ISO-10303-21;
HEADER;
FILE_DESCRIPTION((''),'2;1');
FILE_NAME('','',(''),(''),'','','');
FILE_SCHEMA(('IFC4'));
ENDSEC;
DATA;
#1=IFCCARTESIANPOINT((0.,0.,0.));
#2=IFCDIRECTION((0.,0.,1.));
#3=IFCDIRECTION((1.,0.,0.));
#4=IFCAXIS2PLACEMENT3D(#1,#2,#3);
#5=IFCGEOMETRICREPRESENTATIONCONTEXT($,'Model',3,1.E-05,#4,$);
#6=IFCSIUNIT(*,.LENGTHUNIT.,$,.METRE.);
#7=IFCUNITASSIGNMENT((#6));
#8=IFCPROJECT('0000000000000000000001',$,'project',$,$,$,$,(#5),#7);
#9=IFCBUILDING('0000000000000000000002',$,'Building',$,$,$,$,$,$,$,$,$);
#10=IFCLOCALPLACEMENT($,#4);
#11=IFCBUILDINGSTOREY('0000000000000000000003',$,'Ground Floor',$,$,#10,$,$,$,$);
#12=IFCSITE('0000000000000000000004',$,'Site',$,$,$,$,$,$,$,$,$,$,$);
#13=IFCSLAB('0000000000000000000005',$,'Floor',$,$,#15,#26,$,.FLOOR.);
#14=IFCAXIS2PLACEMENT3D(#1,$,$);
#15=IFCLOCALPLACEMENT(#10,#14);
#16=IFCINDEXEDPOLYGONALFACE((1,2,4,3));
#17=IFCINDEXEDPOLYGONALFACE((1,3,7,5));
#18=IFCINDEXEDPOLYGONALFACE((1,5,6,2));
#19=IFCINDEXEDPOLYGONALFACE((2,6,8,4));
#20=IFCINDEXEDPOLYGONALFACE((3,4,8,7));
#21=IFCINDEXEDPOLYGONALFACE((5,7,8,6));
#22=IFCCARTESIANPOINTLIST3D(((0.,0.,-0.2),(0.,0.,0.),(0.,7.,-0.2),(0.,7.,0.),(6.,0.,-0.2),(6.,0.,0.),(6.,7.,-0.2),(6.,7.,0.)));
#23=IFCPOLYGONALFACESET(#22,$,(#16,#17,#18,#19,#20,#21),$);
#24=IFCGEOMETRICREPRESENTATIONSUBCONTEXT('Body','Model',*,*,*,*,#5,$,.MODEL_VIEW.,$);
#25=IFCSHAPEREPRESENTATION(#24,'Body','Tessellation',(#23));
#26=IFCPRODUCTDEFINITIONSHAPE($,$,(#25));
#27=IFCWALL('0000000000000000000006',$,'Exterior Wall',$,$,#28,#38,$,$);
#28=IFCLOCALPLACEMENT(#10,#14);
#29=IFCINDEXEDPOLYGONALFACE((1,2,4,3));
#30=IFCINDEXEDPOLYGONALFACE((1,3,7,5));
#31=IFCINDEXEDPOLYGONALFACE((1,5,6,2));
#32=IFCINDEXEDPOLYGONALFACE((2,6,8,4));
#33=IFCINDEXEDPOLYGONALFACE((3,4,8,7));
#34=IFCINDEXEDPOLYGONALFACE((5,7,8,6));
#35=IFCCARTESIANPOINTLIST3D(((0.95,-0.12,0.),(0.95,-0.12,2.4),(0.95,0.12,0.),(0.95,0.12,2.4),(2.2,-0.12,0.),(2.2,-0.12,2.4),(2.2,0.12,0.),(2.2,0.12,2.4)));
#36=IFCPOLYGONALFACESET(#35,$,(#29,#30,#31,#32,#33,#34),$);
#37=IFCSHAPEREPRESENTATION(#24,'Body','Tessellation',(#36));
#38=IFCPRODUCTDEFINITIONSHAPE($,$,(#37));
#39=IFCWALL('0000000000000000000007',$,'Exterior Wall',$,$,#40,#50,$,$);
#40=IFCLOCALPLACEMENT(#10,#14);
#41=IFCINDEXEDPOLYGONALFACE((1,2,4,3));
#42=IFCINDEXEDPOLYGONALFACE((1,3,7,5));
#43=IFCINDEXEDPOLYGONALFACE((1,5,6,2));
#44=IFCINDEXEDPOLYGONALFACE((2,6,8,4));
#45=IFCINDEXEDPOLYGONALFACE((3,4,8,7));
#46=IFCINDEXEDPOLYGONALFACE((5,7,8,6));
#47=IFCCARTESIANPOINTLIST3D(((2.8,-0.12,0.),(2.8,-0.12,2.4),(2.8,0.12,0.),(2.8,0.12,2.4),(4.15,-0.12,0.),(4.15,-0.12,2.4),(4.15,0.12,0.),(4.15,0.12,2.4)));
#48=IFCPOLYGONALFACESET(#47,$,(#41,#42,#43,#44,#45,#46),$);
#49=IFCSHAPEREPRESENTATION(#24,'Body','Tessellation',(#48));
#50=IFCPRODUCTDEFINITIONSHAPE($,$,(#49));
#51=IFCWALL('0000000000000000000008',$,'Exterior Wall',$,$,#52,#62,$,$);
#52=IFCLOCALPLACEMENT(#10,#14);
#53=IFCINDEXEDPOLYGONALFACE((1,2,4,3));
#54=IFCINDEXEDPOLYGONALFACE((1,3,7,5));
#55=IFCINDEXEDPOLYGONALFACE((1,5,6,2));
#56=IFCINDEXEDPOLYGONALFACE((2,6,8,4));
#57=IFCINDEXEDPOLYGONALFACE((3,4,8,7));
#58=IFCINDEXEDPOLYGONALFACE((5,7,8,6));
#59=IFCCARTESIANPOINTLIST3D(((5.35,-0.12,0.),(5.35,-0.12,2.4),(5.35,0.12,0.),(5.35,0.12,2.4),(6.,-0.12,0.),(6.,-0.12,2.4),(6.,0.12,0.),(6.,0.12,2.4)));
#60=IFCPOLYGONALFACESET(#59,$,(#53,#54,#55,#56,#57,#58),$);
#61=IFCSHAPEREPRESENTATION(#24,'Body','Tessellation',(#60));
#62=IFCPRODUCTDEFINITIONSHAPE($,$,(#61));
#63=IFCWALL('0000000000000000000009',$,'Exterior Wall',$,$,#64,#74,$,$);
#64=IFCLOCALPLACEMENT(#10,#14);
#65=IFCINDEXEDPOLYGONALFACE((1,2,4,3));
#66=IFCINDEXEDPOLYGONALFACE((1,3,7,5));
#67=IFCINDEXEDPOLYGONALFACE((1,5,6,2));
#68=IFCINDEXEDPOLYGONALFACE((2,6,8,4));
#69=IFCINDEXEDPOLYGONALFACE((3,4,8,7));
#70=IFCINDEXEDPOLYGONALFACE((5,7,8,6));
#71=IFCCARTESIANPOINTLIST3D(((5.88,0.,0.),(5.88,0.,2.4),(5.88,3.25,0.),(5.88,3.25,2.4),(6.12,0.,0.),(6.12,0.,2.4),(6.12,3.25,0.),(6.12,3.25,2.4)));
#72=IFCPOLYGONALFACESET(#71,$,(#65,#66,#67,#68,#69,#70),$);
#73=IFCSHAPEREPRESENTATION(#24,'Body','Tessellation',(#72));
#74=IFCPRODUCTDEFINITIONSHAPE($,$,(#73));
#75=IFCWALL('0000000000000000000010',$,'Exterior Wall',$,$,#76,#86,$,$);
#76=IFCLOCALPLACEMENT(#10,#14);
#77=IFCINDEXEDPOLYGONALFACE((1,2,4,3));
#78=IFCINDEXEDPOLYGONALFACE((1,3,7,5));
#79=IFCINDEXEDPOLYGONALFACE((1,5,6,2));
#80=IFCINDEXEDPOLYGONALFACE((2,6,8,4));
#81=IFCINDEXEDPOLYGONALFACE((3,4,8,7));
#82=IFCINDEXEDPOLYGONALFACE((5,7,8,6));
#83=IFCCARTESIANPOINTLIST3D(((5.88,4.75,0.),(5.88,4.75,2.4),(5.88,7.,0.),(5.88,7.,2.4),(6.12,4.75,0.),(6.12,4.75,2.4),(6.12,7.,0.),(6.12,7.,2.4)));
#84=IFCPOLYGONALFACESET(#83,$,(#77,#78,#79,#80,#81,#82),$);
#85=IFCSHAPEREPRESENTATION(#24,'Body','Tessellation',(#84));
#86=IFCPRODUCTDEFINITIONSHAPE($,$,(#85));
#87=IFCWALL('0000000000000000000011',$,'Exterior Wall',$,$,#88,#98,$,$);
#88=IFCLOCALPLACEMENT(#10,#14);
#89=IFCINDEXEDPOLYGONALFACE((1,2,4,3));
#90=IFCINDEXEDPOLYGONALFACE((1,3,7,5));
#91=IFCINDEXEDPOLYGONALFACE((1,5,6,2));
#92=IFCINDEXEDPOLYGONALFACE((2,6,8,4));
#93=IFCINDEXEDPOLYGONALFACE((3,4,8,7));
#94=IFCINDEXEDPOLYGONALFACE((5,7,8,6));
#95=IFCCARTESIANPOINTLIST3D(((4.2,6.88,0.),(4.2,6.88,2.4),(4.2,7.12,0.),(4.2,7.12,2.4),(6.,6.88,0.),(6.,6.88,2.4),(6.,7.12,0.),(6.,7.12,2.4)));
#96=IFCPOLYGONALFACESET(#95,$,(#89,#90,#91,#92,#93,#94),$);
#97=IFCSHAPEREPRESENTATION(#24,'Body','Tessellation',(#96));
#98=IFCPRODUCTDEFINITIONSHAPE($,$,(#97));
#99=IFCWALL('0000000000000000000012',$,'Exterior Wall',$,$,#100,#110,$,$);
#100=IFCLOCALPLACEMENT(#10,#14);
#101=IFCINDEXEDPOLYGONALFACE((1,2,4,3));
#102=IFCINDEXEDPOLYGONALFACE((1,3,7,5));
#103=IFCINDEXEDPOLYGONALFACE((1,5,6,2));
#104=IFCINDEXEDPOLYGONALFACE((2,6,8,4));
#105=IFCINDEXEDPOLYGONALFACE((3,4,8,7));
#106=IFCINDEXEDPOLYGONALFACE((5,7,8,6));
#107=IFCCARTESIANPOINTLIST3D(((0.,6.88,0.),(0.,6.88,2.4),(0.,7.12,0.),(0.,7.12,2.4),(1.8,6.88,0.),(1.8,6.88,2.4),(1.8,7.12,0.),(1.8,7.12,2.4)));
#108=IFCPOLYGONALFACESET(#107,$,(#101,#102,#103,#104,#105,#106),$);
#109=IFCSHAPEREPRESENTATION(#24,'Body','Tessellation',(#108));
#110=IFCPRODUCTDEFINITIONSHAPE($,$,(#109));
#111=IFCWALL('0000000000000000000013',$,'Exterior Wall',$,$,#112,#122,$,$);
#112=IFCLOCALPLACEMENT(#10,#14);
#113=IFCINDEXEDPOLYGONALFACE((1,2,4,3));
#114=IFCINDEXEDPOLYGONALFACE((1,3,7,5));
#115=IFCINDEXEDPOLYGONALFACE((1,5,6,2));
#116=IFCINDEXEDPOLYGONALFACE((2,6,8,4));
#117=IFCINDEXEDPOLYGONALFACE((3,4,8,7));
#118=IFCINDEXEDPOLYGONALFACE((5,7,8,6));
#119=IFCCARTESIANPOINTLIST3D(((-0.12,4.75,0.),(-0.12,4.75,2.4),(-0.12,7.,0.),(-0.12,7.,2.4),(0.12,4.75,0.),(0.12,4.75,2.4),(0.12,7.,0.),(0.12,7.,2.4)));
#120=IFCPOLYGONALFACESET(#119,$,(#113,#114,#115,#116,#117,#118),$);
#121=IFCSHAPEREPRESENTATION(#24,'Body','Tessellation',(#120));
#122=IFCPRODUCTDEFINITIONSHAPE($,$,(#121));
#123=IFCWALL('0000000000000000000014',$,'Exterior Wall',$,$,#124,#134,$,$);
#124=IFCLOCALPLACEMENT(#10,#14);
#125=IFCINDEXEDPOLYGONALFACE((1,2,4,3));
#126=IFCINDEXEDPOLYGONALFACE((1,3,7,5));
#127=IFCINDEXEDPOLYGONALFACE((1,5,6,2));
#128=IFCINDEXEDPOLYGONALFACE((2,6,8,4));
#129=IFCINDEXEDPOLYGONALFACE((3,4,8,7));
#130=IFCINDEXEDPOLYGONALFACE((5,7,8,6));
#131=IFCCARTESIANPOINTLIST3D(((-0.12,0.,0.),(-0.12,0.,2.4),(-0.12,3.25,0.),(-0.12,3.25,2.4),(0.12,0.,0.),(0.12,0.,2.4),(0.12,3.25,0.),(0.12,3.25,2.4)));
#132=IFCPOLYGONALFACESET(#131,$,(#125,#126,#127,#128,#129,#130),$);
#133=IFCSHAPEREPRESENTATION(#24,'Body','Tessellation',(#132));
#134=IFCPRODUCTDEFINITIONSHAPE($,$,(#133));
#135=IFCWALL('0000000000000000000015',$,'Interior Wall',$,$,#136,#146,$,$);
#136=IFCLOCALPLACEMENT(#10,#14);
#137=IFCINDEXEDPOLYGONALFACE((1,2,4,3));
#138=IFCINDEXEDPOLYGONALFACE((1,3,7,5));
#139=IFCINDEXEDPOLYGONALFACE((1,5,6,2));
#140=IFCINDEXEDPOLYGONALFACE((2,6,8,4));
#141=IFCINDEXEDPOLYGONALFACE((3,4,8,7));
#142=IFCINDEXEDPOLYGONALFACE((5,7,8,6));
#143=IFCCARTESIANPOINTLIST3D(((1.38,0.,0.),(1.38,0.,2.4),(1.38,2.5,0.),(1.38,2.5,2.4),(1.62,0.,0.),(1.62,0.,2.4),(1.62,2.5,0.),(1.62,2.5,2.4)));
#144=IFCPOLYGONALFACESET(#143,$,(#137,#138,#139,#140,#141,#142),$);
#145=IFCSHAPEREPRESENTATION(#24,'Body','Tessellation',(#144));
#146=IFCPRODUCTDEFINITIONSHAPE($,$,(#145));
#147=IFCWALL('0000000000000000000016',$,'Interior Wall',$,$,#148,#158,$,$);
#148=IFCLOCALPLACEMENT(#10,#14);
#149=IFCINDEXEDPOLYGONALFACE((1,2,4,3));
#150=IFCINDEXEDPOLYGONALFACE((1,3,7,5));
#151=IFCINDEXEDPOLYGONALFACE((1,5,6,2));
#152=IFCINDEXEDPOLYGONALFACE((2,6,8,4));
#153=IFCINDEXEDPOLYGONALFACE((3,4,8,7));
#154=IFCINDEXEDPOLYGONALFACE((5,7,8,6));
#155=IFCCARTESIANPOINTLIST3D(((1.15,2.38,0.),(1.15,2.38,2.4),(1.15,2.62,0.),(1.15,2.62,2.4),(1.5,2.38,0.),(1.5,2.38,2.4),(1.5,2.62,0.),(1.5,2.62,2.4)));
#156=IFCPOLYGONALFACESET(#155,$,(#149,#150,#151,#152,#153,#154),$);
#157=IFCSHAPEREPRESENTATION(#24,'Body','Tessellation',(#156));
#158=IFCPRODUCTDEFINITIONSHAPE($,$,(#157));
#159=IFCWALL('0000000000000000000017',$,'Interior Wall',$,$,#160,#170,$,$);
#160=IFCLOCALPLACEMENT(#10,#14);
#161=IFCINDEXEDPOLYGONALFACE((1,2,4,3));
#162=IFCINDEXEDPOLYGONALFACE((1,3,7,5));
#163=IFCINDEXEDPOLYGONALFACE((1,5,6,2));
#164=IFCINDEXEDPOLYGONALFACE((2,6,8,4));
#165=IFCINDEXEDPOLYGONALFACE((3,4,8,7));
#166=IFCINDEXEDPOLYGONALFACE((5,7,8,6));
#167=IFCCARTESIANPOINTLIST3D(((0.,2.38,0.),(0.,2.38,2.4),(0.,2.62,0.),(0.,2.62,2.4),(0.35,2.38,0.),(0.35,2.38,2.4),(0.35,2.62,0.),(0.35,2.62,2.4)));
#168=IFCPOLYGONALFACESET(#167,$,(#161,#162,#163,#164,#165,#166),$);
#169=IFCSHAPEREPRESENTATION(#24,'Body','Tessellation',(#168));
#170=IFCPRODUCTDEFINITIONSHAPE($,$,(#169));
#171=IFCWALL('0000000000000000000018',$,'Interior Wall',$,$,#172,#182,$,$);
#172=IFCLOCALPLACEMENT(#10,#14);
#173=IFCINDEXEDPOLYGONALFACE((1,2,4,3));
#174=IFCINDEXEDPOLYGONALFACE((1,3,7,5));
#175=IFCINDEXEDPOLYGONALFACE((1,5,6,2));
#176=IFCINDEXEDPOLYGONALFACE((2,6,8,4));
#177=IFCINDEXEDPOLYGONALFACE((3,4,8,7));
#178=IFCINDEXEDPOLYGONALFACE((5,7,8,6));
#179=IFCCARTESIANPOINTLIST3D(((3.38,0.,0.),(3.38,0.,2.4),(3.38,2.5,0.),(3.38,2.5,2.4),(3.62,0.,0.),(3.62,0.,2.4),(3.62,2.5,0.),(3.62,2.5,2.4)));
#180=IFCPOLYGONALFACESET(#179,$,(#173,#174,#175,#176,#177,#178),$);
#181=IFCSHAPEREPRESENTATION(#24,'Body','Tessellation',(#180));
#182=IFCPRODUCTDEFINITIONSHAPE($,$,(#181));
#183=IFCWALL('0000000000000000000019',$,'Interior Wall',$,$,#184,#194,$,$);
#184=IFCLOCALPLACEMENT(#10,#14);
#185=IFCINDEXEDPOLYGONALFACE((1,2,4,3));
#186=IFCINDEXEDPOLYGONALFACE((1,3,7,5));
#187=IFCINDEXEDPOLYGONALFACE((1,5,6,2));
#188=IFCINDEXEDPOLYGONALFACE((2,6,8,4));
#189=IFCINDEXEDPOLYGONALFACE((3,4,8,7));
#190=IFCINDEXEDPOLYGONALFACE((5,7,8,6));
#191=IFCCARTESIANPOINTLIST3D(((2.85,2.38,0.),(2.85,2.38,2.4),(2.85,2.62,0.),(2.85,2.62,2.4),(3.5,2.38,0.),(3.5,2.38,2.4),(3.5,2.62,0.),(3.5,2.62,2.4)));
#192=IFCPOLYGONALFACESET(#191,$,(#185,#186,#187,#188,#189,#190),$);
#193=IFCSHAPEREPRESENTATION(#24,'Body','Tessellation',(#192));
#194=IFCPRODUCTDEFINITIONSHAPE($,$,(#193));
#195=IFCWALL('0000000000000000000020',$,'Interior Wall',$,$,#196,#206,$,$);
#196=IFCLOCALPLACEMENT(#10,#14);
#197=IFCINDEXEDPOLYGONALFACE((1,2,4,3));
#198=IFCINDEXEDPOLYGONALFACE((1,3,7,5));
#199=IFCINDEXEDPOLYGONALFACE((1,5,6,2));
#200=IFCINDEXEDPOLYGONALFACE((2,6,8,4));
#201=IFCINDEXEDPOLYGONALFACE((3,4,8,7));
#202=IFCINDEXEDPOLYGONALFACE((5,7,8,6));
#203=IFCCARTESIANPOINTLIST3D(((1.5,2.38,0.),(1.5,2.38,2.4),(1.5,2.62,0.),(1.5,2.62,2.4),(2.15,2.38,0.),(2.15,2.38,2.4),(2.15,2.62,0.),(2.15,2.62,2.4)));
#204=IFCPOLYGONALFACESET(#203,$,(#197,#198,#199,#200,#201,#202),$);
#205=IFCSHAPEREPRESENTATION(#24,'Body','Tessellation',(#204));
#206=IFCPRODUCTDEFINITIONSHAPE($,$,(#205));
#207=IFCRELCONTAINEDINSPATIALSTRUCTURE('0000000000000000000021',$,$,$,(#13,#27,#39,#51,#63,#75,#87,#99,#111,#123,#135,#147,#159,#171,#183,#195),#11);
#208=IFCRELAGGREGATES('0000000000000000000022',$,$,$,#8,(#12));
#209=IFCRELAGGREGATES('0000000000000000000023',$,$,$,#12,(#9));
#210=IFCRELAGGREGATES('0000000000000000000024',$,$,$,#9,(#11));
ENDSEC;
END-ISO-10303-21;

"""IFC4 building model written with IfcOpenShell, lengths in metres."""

from ifc_helpers import new_model, si_unit, frame, origin_with_axes, place, context, subcontext, project, spatial, indexed_curve, outline, extrude, element, save


model = new_model("IFC4")

# Units and contexts
model_context = context("Model", 3, precision=1e-05, world=origin_with_axes())
body_context = subcontext(model_context, "Body", "Model", "MODEL_VIEW")
ifc_project = project(units=[si_unit("LENGTHUNIT", "METRE")], contexts=[model_context])

# Site, building, storey
site = spatial("IfcSite", under=ifc_project, Name="Site")
building = spatial("IfcBuilding", under=site, Name="Building")
storey_placement = place(None, origin_with_axes())
storey = spatial("IfcBuildingStorey", under=building, at=storey_placement, Name="Ground Floor")

# Slab
slab_placement = place(storey_placement, frame((0.0, 0.0, -0.2), z_axis=(0.0, 0.0, 1.0), x_axis=(1.0, 0.0, 0.0)))
element("IfcSlab", 1, at=slab_placement, inside=storey, Name="Floor", PredefinedType="FLOOR", context=body_context, shape_type="SweptSolid", body=[
    extrude(outline(indexed_curve([(0.0, 0.0), (6.0, 0.0), (6.0, 7.0), (0.0, 7.0)])), None, (0.0, 0.0, 1.0), 0.2),
])

# Walls
wall_1_placement = place(storey_placement, frame((0.95, 0.0, 0.0), z_axis=(0.0, 0.0, 1.0), x_axis=(1.0, 0.0, 0.0)))
element("IfcWall", 2, at=wall_1_placement, inside=storey, Name="Exterior Wall", context=body_context, shape_type="SweptSolid", body=[
    extrude(outline(indexed_curve([(0.0, 0.0), (0.0, 0.24), (1.25, 0.24), (1.25, 0.0), (0.0, 0.0)], self_intersect=False)), frame((0.0, -0.12, 0.0), z_axis=(0.0, 0.0, 1.0), x_axis=(1.0, 0.0, 0.0)), (0.0, 0.0, 1.0), 2.4),
])
wall_2_placement = place(storey_placement, frame((2.8, 0.0, 0.0), z_axis=(0.0, 0.0, 1.0), x_axis=(1.0, 0.0, 0.0)))
element("IfcWall", 3, at=wall_2_placement, inside=storey, Name="Exterior Wall", context=body_context, shape_type="SweptSolid", body=[
    extrude(outline(indexed_curve([(0.0, 0.0), (0.0, 0.24), (1.35, 0.24), (1.35, 0.0), (0.0, 0.0)], self_intersect=False)), frame((0.0, -0.12, 0.0), z_axis=(0.0, 0.0, 1.0), x_axis=(1.0, 0.0, 0.0)), (0.0, 0.0, 1.0), 2.4),
])
wall_3_placement = place(storey_placement, frame((5.35, 0.0, 0.0), z_axis=(0.0, 0.0, 1.0), x_axis=(1.0, 0.0, 0.0)))
element("IfcWall", 4, at=wall_3_placement, inside=storey, Name="Exterior Wall", context=body_context, shape_type="SweptSolid", body=[
    extrude(outline(indexed_curve([(0.0, 0.0), (0.0, 0.24), (0.65, 0.24), (0.65, 0.0), (0.0, 0.0)], self_intersect=False)), frame((0.0, -0.12, 0.0), z_axis=(0.0, 0.0, 1.0), x_axis=(1.0, 0.0, 0.0)), (0.0, 0.0, 1.0), 2.4),
])
wall_4_placement = place(storey_placement, frame((6.0, 0.0, 0.0), z_axis=(0.0, 0.0, 1.0), x_axis=(0.0, 1.0, 0.0)))
element("IfcWall", 5, at=wall_4_placement, inside=storey, Name="Exterior Wall", context=body_context, shape_type="SweptSolid", body=[
    extrude(outline(indexed_curve([(0.0, 0.0), (0.0, 0.24), (3.25, 0.24), (3.25, 0.0), (0.0, 0.0)], self_intersect=False)), frame((0.0, -0.12, 0.0), z_axis=(0.0, 0.0, 1.0), x_axis=(1.0, 0.0, 0.0)), (0.0, 0.0, 1.0), 2.4),
])
wall_5_placement = place(storey_placement, frame((6.0, 4.75, 0.0), z_axis=(0.0, 0.0, 1.0), x_axis=(0.0, 1.0, 0.0)))
element("IfcWall", 6, at=wall_5_placement, inside=storey, Name="Exterior Wall", context=body_context, shape_type="SweptSolid", body=[
    extrude(outline(indexed_curve([(0.0, 0.0), (0.0, 0.24), (2.25, 0.24), (2.25, 0.0), (0.0, 0.0)], self_intersect=False)), frame((0.0, -0.12, 0.0), z_axis=(0.0, 0.0, 1.0), x_axis=(1.0, 0.0, 0.0)), (0.0, 0.0, 1.0), 2.4),
])
for number, where, z_axis, x_axis, name in (
    (7, (6.0, 7.0, 0.0), (0.0, 0.0, 1.0), (-1.0, 0.0, 0.0), "Exterior Wall"),
    (8, (1.8, 7.0, 0.0), (0.0, 0.0, 1.0), (-1.0, 0.0, 0.0), "Exterior Wall"),
):
    element("IfcWall", number, at=place(storey_placement, frame(where, z_axis=z_axis, x_axis=x_axis)), inside=storey, Name=name, context=body_context, shape_type="SweptSolid", body=[
        extrude(outline(indexed_curve([(0.0, 0.0), (0.0, 0.24), (1.8, 0.24), (1.8, 0.0), (0.0, 0.0)], self_intersect=False)), frame((0.0, -0.12, 0.0), z_axis=(0.0, 0.0, 1.0), x_axis=(1.0, 0.0, 0.0)), (0.0, 0.0, 1.0), 2.4),
    ])
wall_6_placement = place(storey_placement, frame((0.0, 7.0, 0.0), z_axis=(0.0, 0.0, 1.0), x_axis=(0.0, -1.0, 0.0)))
element("IfcWall", 9, at=wall_6_placement, inside=storey, Name="Exterior Wall", context=body_context, shape_type="SweptSolid", body=[
    extrude(outline(indexed_curve([(0.0, 0.0), (0.0, 0.24), (2.25, 0.24), (2.25, 0.0), (0.0, 0.0)], self_intersect=False)), frame((0.0, -0.12, 0.0), z_axis=(0.0, 0.0, 1.0), x_axis=(1.0, 0.0, 0.0)), (0.0, 0.0, 1.0), 2.4),
])
wall_7_placement = place(storey_placement, frame((0.0, 3.25, 0.0), z_axis=(0.0, 0.0, 1.0), x_axis=(0.0, -1.0, 0.0)))
element("IfcWall", 10, at=wall_7_placement, inside=storey, Name="Exterior Wall", context=body_context, shape_type="SweptSolid", body=[
    extrude(outline(indexed_curve([(0.0, 0.0), (0.0, 0.24), (3.25, 0.24), (3.25, 0.0), (0.0, 0.0)], self_intersect=False)), frame((0.0, -0.12, 0.0), z_axis=(0.0, 0.0, 1.0), x_axis=(1.0, 0.0, 0.0)), (0.0, 0.0, 1.0), 2.4),
])
wall_8_placement = place(storey_placement, frame((1.5, 0.0, 0.0), z_axis=(0.0, 0.0, 1.0), x_axis=(0.0, 1.0, 0.0)))
element("IfcWall", 11, at=wall_8_placement, inside=storey, Name="Interior Wall", context=body_context, shape_type="SweptSolid", body=[
    extrude(outline(indexed_curve([(0.0, 0.0), (0.0, 0.24), (2.5, 0.24), (2.5, 0.0), (0.0, 0.0)], self_intersect=False)), frame((0.0, -0.12, 0.0), z_axis=(0.0, 0.0, 1.0), x_axis=(1.0, 0.0, 0.0)), (0.0, 0.0, 1.0), 2.4),
])
for number, where, z_axis, x_axis, name in (
    (12, (1.5, 2.5, 0.0), (0.0, 0.0, 1.0), (-1.0, 0.0, 0.0), "Interior Wall"),
    (13, (0.35, 2.5, 0.0), (0.0, 0.0, 1.0), (-1.0, 0.0, 0.0), "Interior Wall"),
):
    element("IfcWall", number, at=place(storey_placement, frame(where, z_axis=z_axis, x_axis=x_axis)), inside=storey, Name=name, context=body_context, shape_type="SweptSolid", body=[
        extrude(outline(indexed_curve([(0.0, 0.0), (0.0, 0.24), (0.35, 0.24), (0.35, 0.0), (0.0, 0.0)], self_intersect=False)), frame((0.0, -0.12, 0.0), z_axis=(0.0, 0.0, 1.0), x_axis=(1.0, 0.0, 0.0)), (0.0, 0.0, 1.0), 2.4),
    ])
wall_9_placement = place(storey_placement, frame((3.5, 0.0, 0.0), z_axis=(0.0, 0.0, 1.0), x_axis=(0.0, 1.0, 0.0)))
element("IfcWall", 14, at=wall_9_placement, inside=storey, Name="Interior Wall", context=body_context, shape_type="SweptSolid", body=[
    extrude(outline(indexed_curve([(0.0, 0.0), (0.0, 0.24), (2.5, 0.24), (2.5, 0.0), (0.0, 0.0)], self_intersect=False)), frame((0.0, -0.12, 0.0), z_axis=(0.0, 0.0, 1.0), x_axis=(1.0, 0.0, 0.0)), (0.0, 0.0, 1.0), 2.4),
])
for number, where, z_axis, x_axis, name in (
    (15, (3.5, 2.5, 0.0), (0.0, 0.0, 1.0), (-1.0, 0.0, 0.0), "Interior Wall"),
    (16, (2.15, 2.5, 0.0), (0.0, 0.0, 1.0), (-1.0, 0.0, 0.0), "Interior Wall"),
):
    element("IfcWall", number, at=place(storey_placement, frame(where, z_axis=z_axis, x_axis=x_axis)), inside=storey, Name=name, context=body_context, shape_type="SweptSolid", body=[
        extrude(outline(indexed_curve([(0.0, 0.0), (0.0, 0.24), (0.65, 0.24), (0.65, 0.0), (0.0, 0.0)], self_intersect=False)), frame((0.0, -0.12, 0.0), z_axis=(0.0, 0.0, 1.0), x_axis=(1.0, 0.0, 0.0)), (0.0, 0.0, 1.0), 2.4),
    ])

save(model, "model.ifc")
